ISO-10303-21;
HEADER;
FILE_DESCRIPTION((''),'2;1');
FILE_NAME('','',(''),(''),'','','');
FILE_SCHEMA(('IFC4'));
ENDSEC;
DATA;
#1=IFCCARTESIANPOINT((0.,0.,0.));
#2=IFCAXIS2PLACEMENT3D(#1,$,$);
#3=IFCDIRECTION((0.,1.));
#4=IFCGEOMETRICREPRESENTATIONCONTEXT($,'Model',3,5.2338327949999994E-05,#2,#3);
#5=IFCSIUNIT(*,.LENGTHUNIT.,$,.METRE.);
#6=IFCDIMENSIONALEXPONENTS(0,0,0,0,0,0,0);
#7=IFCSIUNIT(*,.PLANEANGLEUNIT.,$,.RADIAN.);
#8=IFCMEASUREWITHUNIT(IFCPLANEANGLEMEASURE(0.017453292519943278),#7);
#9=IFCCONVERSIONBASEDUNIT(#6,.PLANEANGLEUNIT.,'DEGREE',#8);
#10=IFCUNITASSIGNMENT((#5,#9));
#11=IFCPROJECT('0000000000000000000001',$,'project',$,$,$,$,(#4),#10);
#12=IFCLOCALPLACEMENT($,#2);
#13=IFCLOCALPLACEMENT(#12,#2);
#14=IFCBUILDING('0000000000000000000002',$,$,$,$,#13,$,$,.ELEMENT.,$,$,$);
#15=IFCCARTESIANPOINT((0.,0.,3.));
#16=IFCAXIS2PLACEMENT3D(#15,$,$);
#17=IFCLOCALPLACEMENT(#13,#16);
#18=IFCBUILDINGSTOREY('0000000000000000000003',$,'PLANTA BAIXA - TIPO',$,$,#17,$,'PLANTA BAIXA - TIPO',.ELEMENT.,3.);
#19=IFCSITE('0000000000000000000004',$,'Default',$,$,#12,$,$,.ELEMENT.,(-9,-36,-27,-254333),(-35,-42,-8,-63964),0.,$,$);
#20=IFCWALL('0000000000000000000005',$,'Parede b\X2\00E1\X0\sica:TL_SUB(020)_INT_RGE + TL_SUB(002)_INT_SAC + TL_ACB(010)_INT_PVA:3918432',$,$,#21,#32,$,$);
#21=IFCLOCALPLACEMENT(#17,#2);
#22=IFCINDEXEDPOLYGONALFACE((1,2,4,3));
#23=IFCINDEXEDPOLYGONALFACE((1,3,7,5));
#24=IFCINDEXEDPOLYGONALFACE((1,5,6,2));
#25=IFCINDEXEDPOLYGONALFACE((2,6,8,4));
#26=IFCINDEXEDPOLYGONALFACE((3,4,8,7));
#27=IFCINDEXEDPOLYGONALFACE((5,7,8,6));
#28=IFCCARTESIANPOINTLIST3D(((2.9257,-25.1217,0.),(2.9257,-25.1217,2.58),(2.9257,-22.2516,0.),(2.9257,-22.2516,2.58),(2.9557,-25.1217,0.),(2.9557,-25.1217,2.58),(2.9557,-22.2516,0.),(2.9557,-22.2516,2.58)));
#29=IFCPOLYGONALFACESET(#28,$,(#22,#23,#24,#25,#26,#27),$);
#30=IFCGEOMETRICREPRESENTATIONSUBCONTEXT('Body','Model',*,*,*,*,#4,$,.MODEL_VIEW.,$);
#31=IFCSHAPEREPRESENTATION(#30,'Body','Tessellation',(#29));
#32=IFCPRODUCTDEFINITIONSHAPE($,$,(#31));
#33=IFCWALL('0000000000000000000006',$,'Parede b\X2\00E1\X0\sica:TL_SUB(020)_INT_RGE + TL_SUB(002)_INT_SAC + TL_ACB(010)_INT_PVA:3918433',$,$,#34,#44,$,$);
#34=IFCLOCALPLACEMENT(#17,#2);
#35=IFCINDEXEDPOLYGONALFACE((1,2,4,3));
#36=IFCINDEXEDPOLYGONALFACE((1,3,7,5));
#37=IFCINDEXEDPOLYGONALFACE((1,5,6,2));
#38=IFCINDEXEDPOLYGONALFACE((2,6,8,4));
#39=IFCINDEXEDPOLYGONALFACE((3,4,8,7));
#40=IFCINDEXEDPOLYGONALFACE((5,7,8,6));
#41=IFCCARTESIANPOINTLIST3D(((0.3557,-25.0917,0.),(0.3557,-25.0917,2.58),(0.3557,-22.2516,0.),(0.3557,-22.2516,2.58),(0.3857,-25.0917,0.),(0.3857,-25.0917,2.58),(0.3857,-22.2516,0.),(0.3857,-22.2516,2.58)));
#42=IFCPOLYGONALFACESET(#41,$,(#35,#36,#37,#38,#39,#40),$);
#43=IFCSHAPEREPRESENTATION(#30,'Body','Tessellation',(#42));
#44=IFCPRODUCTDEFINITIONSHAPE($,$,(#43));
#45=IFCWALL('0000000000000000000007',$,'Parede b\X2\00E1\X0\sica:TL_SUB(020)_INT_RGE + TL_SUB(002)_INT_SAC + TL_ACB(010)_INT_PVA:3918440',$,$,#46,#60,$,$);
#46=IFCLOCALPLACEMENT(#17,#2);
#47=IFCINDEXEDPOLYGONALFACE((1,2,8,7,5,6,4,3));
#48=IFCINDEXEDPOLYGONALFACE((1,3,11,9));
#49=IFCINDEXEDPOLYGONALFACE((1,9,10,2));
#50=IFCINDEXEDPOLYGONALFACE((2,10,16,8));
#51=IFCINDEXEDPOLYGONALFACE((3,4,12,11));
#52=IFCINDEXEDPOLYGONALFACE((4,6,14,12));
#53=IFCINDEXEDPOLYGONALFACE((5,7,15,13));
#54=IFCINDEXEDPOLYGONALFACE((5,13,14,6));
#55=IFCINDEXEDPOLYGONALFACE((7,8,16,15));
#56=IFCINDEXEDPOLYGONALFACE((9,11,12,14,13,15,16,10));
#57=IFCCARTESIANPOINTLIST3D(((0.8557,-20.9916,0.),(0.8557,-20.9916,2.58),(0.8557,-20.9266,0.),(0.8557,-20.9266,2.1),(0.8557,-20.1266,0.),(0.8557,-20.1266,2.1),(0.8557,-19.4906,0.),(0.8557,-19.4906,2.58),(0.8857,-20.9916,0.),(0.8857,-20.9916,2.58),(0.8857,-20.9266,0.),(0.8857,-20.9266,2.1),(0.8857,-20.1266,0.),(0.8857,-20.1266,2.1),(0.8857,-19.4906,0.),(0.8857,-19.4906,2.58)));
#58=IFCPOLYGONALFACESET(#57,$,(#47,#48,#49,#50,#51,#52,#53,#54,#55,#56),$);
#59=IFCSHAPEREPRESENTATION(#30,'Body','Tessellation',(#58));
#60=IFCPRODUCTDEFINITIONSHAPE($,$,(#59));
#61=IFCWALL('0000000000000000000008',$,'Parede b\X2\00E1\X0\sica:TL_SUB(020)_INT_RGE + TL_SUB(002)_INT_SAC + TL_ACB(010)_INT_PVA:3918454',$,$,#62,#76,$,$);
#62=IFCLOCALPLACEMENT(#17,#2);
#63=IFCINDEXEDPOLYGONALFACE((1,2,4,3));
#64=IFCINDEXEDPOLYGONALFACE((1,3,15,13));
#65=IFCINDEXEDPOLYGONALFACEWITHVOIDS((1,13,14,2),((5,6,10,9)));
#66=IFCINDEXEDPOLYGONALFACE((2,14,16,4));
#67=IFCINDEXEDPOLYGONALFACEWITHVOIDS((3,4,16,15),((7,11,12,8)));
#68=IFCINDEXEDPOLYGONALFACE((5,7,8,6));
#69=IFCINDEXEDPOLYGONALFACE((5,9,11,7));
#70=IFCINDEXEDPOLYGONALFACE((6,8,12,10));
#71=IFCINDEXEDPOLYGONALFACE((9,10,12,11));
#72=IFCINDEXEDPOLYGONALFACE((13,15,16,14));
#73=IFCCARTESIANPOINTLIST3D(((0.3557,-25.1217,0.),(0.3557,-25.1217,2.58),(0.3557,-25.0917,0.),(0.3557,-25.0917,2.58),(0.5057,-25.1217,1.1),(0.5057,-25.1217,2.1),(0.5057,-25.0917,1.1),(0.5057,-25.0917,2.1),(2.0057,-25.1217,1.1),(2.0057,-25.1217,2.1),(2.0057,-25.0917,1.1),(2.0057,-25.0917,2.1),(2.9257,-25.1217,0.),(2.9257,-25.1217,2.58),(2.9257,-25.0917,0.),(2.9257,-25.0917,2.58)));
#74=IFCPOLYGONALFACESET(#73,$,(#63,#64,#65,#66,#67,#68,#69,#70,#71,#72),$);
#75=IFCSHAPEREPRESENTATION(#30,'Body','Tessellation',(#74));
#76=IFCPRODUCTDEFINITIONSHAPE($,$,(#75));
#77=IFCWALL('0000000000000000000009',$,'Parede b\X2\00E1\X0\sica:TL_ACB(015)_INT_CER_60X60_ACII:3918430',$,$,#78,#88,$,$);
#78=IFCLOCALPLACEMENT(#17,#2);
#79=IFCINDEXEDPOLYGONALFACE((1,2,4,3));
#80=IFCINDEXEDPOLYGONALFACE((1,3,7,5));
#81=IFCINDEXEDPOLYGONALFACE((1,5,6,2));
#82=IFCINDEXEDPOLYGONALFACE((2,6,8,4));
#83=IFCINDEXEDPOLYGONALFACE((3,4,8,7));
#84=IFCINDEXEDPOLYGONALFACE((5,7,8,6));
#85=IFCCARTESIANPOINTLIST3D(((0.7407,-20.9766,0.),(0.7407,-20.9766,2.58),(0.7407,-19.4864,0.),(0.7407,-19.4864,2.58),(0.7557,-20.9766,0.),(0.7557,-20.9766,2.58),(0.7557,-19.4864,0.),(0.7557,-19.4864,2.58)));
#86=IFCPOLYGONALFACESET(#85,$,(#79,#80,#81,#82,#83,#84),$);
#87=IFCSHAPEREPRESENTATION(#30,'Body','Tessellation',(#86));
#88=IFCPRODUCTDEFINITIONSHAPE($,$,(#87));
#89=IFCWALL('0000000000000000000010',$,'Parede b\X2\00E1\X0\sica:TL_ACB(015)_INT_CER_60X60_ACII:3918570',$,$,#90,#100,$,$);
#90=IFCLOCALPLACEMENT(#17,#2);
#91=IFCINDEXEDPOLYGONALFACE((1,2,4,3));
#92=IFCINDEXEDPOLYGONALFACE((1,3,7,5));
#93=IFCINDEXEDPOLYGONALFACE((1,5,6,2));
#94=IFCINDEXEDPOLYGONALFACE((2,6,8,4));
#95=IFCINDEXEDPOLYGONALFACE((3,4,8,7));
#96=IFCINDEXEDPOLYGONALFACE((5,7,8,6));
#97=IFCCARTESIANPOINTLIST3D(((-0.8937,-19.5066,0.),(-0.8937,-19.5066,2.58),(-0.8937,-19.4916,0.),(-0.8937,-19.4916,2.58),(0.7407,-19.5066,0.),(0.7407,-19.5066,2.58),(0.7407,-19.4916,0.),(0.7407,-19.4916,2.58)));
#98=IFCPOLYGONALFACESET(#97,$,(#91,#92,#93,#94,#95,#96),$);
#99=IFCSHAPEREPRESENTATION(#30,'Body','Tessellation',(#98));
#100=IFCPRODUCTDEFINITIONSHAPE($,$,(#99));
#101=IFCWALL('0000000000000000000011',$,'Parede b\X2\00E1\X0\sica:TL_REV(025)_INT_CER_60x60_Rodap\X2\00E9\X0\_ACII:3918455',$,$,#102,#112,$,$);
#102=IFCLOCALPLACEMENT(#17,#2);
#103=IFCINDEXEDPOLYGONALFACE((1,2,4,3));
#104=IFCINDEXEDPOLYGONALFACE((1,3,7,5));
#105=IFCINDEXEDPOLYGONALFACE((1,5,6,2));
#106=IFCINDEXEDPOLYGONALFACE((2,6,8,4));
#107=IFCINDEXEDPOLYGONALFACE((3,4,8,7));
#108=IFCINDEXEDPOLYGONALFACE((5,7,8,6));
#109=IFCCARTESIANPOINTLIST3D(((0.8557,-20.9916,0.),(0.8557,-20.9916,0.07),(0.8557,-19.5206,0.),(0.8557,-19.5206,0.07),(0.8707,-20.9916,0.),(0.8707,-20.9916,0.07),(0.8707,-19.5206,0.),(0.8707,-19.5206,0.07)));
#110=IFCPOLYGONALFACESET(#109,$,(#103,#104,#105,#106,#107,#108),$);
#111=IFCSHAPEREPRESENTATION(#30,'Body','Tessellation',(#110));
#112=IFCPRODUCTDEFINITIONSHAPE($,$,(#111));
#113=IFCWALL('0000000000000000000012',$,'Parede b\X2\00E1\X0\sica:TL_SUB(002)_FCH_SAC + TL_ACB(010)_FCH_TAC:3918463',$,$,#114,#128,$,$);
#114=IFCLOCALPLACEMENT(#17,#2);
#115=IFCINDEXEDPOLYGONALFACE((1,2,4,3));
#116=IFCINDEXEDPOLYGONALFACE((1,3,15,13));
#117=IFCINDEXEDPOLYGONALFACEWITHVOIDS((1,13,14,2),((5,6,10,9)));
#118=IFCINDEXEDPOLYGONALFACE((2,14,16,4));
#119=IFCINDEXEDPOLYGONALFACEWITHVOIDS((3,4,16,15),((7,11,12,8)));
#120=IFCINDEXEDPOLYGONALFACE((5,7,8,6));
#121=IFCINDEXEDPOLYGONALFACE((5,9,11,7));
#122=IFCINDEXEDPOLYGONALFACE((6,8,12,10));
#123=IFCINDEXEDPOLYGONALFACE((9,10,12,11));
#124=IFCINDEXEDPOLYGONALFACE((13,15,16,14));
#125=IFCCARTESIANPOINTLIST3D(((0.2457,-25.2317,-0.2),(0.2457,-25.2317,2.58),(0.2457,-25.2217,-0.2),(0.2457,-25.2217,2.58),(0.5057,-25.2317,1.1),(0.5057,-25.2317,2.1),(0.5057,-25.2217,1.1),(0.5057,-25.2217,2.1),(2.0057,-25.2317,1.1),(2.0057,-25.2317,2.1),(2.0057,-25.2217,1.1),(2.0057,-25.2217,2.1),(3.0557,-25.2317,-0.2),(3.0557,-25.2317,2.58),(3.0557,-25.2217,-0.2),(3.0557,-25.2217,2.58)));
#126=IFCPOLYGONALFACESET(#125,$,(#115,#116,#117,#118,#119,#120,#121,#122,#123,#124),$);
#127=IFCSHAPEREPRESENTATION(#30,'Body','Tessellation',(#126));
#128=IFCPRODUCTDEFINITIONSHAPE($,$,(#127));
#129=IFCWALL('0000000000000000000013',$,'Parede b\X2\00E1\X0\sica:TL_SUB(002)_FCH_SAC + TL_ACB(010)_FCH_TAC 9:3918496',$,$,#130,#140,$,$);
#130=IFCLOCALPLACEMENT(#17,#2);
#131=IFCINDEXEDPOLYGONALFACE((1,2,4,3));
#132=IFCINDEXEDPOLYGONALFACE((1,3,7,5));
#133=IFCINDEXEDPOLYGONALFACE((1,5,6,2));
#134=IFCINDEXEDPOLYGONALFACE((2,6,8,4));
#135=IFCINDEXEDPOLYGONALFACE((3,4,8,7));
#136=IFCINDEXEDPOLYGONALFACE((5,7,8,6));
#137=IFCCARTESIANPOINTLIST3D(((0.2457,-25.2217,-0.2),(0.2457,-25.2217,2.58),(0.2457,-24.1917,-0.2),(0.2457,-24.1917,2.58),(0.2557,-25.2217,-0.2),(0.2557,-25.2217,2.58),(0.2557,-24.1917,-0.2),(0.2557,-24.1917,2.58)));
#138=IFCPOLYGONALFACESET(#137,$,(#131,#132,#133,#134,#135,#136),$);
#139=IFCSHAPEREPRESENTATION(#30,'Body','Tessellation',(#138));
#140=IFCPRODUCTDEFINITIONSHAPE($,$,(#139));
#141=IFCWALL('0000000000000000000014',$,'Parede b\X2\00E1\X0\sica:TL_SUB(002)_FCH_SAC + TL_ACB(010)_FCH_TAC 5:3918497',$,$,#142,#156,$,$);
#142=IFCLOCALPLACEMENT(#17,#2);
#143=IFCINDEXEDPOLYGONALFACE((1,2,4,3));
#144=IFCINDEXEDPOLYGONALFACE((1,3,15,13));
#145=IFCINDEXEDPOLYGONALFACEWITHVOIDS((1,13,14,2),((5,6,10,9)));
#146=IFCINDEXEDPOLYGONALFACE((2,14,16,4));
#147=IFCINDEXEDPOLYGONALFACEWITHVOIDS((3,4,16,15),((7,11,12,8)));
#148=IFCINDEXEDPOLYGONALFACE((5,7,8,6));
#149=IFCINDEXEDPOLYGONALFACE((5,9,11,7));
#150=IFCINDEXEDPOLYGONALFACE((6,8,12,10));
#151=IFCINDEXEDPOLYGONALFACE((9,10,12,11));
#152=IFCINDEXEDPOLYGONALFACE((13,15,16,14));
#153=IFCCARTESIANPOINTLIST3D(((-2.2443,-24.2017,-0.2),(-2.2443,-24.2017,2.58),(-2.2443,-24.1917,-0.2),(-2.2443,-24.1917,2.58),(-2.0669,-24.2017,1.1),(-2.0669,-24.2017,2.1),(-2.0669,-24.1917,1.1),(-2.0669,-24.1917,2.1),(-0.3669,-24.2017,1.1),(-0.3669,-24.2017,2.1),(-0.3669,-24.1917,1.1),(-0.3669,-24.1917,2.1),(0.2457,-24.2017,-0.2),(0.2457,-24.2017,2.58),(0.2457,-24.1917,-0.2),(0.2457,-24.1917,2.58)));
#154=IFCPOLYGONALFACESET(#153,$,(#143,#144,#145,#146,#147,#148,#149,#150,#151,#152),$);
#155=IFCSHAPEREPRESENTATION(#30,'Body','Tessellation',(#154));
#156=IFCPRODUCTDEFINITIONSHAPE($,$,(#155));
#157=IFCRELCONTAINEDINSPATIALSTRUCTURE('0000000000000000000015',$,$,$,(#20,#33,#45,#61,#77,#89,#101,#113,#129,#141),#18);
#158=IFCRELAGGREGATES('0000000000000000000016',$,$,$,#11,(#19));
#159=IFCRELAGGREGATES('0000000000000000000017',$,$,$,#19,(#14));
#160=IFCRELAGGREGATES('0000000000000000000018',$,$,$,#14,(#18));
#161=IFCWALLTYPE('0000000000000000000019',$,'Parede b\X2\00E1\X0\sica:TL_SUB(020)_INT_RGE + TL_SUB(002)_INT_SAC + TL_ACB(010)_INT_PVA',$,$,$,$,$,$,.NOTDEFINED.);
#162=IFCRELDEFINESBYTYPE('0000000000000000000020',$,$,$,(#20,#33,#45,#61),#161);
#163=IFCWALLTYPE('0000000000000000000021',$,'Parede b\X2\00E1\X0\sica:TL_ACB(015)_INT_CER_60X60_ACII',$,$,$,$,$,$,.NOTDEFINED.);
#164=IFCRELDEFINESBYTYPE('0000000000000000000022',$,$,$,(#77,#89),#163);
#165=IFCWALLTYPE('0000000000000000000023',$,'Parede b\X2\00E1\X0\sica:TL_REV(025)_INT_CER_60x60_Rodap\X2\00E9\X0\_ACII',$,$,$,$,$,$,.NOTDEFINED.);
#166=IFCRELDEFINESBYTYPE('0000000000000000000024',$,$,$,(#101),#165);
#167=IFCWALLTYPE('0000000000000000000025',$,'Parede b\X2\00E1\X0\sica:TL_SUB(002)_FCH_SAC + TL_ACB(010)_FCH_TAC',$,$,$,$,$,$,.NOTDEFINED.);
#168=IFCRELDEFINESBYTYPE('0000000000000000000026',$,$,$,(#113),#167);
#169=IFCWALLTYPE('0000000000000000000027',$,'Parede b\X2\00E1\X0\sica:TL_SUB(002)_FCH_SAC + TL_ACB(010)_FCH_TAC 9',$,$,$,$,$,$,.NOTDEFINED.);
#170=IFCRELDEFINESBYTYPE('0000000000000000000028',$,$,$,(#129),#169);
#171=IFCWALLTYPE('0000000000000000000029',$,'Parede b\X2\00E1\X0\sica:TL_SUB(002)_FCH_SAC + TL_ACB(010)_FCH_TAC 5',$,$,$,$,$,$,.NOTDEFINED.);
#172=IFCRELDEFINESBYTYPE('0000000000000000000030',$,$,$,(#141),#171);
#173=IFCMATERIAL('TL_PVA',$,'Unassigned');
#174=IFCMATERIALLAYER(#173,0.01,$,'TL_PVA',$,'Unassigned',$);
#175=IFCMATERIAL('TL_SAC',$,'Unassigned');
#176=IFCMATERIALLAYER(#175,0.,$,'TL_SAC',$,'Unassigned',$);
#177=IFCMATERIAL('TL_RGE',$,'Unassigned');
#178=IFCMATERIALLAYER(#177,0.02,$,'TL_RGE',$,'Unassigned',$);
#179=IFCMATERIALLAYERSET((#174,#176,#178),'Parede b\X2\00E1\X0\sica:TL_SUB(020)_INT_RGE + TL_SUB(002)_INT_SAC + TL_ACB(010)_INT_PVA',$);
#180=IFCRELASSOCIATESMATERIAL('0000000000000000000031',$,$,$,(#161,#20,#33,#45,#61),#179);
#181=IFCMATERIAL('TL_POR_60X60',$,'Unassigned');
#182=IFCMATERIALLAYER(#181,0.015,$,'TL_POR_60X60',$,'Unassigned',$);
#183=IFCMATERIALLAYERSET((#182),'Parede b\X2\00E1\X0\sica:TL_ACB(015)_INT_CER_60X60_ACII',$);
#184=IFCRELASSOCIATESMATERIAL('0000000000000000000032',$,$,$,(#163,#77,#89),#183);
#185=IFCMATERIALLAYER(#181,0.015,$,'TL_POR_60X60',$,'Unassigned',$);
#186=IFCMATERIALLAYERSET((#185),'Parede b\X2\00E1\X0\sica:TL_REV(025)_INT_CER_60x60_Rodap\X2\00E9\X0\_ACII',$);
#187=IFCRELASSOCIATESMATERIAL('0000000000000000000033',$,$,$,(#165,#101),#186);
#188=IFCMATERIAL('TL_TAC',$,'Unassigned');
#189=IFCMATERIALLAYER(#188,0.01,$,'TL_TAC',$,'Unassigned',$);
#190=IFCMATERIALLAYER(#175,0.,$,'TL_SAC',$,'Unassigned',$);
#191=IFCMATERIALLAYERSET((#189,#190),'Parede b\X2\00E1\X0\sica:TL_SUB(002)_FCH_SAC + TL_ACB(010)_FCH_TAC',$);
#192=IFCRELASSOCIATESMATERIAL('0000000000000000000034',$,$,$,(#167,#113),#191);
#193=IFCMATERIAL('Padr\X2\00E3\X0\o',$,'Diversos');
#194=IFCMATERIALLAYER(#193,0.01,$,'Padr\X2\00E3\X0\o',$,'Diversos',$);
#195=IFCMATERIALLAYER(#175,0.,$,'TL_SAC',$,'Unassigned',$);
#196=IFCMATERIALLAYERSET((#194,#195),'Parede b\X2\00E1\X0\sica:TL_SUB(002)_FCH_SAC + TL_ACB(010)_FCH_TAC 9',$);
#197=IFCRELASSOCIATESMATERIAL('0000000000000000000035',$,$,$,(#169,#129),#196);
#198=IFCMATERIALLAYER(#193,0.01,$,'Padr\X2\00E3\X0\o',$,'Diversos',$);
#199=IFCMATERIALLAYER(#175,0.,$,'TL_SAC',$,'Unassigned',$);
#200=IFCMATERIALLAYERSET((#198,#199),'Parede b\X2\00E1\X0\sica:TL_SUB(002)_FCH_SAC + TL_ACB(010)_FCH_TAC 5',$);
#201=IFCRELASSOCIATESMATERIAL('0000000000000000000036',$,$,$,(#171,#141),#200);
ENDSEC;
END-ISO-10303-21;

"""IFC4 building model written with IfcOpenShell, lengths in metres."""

from ifc_helpers import new_model, entity, si_unit, converted_unit, direction, frame, frame_2d, origin, place, context, subcontext, project, spatial, rectangle, extrude, material, layer, layer_set, layer_usage, type_object, element, save


model = new_model("IFC4")

# Units and contexts
model_context = context("Model", 3, precision=5.2338327949999994e-05, world=origin(), true_north=direction((0.0, 1.0)))
body_context = subcontext(model_context, "Body", "Model", "MODEL_VIEW")
ifc_project = project(units=[si_unit("LENGTHUNIT", "METRE"), converted_unit("PLANEANGLEUNIT", "DEGREE", entity("IfcPlaneAngleMeasure", 0.017453292519943278), si_unit("PLANEANGLEUNIT", "RADIAN"), dimensions=[0, 0, 0, 0, 0, 0, 0])], contexts=[model_context])

# Site, building, storey
site_placement = place(None, frame((0.0, 0.0, 0.0)))
site = spatial("IfcSite", under=ifc_project, at=site_placement, Name="Default", CompositionType="ELEMENT", RefLatitude=(-9, -36, -27, -254333), RefLongitude=(-35, -42, -8, -63964), RefElevation=0.0)
building_placement = place(site_placement, origin())
building = spatial("IfcBuilding", under=site, at=building_placement, CompositionType="ELEMENT")
storey_placement = place(building_placement, frame((0.0, 0.0, 3.0)))
storey = spatial("IfcBuildingStorey", under=building, at=storey_placement, Name="PLANTA BAIXA - TIPO", LongName="PLANTA BAIXA - TIPO", CompositionType="ELEMENT", Elevation=3.0)

# Shared definitions
ifc_material_1 = material(Name="TL_PVA", Category="Unassigned")
ifc_layer_1 = layer(ifc_material_1, 0.01, Name="TL_PVA", Category="Unassigned")
ifc_material_2 = material(Name="TL_SAC", Category="Unassigned")
ifc_layer_2 = layer(ifc_material_2, 0.0, Name="TL_SAC", Category="Unassigned")
ifc_material_3 = material(Name="TL_RGE", Category="Unassigned")
ifc_layer_3 = layer(ifc_material_3, 0.02, Name="TL_RGE", Category="Unassigned")
ifc_layer_set_1 = layer_set([ifc_layer_1, ifc_layer_2, ifc_layer_3], Name="Parede básica:TL_SUB(020)_INT_RGE + TL_SUB(002)_INT_SAC + TL_ACB(010)_INT_PVA")
wall_type_1 = type_object("IfcWallType", Name="Parede básica:TL_SUB(020)_INT_RGE + TL_SUB(002)_INT_SAC + TL_ACB(010)_INT_PVA", PredefinedType="NOTDEFINED", material=ifc_layer_set_1)

# Walls
ifc_layer_usage_1 = layer_usage(ifc_layer_set_1, "AXIS2", "POSITIVE", -0.015)
wall_1_placement = place(storey_placement, frame((2.9407, -22.2516, 0.0), z_axis=(0.0, 0.0, 1.0), x_axis=(0.0, -1.0, 0.0)))
element("IfcWall", 1, at=wall_1_placement, inside=storey, type_object=wall_type_1, material=ifc_layer_usage_1, Name="Parede básica:TL_SUB(020)_INT_RGE + TL_SUB(002)_INT_SAC + TL_ACB(010)_INT_PVA:3918432", context=body_context, shape_type="SweptSolid", body=[
    extrude(rectangle(XDim=2.8701, YDim=0.03, at=frame_2d((1.4351, 0.0), x_axis=(-1.0, 0.0))), origin(), (0.0, 0.0, 1.0), 2.58),
])
ifc_layer_usage_2 = layer_usage(ifc_layer_set_1, "AXIS2", "POSITIVE", -0.015)
wall_2_placement = place(storey_placement, frame((0.3707, -25.0917, 0.0), z_axis=(0.0, 0.0, 1.0), x_axis=(0.0, 1.0, 0.0)))
element("IfcWall", 2, at=wall_2_placement, inside=storey, type_object=wall_type_1, material=ifc_layer_usage_2, Name="Parede básica:TL_SUB(020)_INT_RGE + TL_SUB(002)_INT_SAC + TL_ACB(010)_INT_PVA:3918433", context=body_context, shape_type="SweptSolid", body=[
    extrude(rectangle(XDim=2.8401, YDim=0.03, at=frame_2d((1.4201, 0.0), x_axis=(-1.0, 0.0))), origin(), (0.0, 0.0, 1.0), 2.58),
])

# Walls, openings
ifc_layer_usage_3 = layer_usage(ifc_layer_set_1, "AXIS2", "POSITIVE", -0.015)
wall_3_placement = place(storey_placement, frame((0.8707, -20.9916, 0.0), z_axis=(0.0, 0.0, 1.0), x_axis=(0.0, 1.0, 0.0)))
wall_3 = element("IfcWall", 3, at=wall_3_placement, inside=storey, type_object=wall_type_1, material=ifc_layer_usage_3, Name="Parede básica:TL_SUB(020)_INT_RGE + TL_SUB(002)_INT_SAC + TL_ACB(010)_INT_PVA:3918440", context=body_context, shape_type="SweptSolid", body=[
    extrude(rectangle(XDim=1.501, YDim=0.03, at=frame_2d((0.7505, 0.0), x_axis=(-1.0, 0.0))), origin(), (0.0, 0.0, 1.0), 2.58),
])
opening_1_placement = place(wall_3_placement, frame((0.065, -0.015, 0.0)))
element("IfcOpeningElement", 4, at=opening_1_placement, cuts=wall_3, PredefinedType="OPENING", context=body_context, shape_type="SweptSolid", body=[
    extrude(rectangle(XDim=2.1, YDim=0.8, at=frame_2d((1.05, 0.4), x_axis=(1.0, 0.0))), frame((0.0, 0.0, 0.0), z_axis=(0.0, 1.0, 0.0), x_axis=(0.0, 0.0, 1.0)), (0.0, 0.0, 1.0), 0.03),
])
ifc_layer_usage_4 = layer_usage(ifc_layer_set_1, "AXIS2", "POSITIVE", -0.015)
wall_4_placement = place(storey_placement, frame((2.9257, -25.1067, 0.0), z_axis=(0.0, 0.0, 1.0), x_axis=(-1.0, 0.0, 0.0)))
wall_4 = element("IfcWall", 5, at=wall_4_placement, inside=storey, type_object=wall_type_1, material=ifc_layer_usage_4, Name="Parede básica:TL_SUB(020)_INT_RGE + TL_SUB(002)_INT_SAC + TL_ACB(010)_INT_PVA:3918454", context=body_context, shape_type="SweptSolid", body=[
    extrude(rectangle(XDim=2.57, YDim=0.03, at=frame_2d((1.285, 0.0), x_axis=(-1.0, 0.0))), origin(), (0.0, 0.0, 1.0), 2.58),
])
opening_2_placement = place(wall_4_placement, frame((2.9257, -25.1067, 1.1)))
element("IfcOpeningElement", 6, at=opening_2_placement, cuts=wall_4, PredefinedType="OPENING", context=body_context, shape_type="SweptSolid", body=[
    extrude(rectangle(XDim=1.0, YDim=1.5, at=frame_2d((0.0, 0.0), x_axis=(0.0, 1.0))), frame((-1.2557, 23.5977, 0.5), z_axis=(0.0, 1.0, 0.0), x_axis=(1.0, 0.0, 0.0)), (0.0, 0.0, 1.0), 3.048),
])

# Walls
ifc_material_4 = material(Name="TL_POR_60X60", Category="Unassigned")
ifc_layer_4 = layer(ifc_material_4, 0.015, Name="TL_POR_60X60", Category="Unassigned")
ifc_layer_set_2 = layer_set([ifc_layer_4], Name="Parede básica:TL_ACB(015)_INT_CER_60X60_ACII")
ifc_layer_usage_5 = layer_usage(ifc_layer_set_2, "AXIS2", "POSITIVE", -0.0075)
wall_type_2 = type_object("IfcWallType", Name="Parede básica:TL_ACB(015)_INT_CER_60X60_ACII", PredefinedType="NOTDEFINED", material=ifc_layer_set_2)
wall_5_placement = place(storey_placement, frame((0.7482, -19.4864, 0.0), z_axis=(0.0, 0.0, 1.0), x_axis=(0.0, -1.0, 0.0)))
element("IfcWall", 7, at=wall_5_placement, inside=storey, type_object=wall_type_2, material=ifc_layer_usage_5, Name="Parede básica:TL_ACB(015)_INT_CER_60X60_ACII:3918430", context=body_context, shape_type="SweptSolid", body=[
    extrude(rectangle(XDim=1.4902, YDim=0.015, at=frame_2d((0.7451, 0.0), x_axis=(-1.0, 0.0))), origin(), (0.0, 0.0, 1.0), 2.58),
])
ifc_layer_usage_6 = layer_usage(ifc_layer_set_2, "AXIS2", "NEGATIVE", 0.0075)
wall_6_placement = place(storey_placement, frame((0.7407, -19.4991, 0.0), z_axis=(0.0, 0.0, 1.0), x_axis=(-1.0, 0.0, 0.0)))
element("IfcWall", 8, at=wall_6_placement, inside=storey, type_object=wall_type_2, material=ifc_layer_usage_6, Name="Parede básica:TL_ACB(015)_INT_CER_60X60_ACII:3918570", context=body_context, shape_type="SweptSolid", body=[
    extrude(rectangle(XDim=1.6345, YDim=0.015, at=frame_2d((0.8172, 0.0), x_axis=(-1.0, 0.0))), origin(), (0.0, 0.0, 1.0), 2.58),
])
ifc_layer_5 = layer(ifc_material_4, 0.015, Name="TL_POR_60X60", Category="Unassigned")
ifc_layer_set_3 = layer_set([ifc_layer_5], Name="Parede básica:TL_REV(025)_INT_CER_60x60_Rodapé_ACII")
ifc_layer_usage_7 = layer_usage(ifc_layer_set_3, "AXIS2", "NEGATIVE", 0.0075)
wall_type_3 = type_object("IfcWallType", Name="Parede básica:TL_REV(025)_INT_CER_60x60_Rodapé_ACII", PredefinedType="NOTDEFINED", material=ifc_layer_set_3)
wall_7_placement = place(storey_placement, frame((0.8632, -19.5206, 0.0), z_axis=(0.0, 0.0, 1.0), x_axis=(0.0, -1.0, 0.0)))
element("IfcWall", 9, at=wall_7_placement, inside=storey, type_object=wall_type_3, material=ifc_layer_usage_7, Name="Parede básica:TL_REV(025)_INT_CER_60x60_Rodapé_ACII:3918455", context=body_context, shape_type="SweptSolid", body=[
    extrude(rectangle(XDim=1.471, YDim=0.015, at=frame_2d((0.7355, 0.0), x_axis=(-1.0, 0.0))), origin(), (0.0, 0.0, 1.0), 0.07),
])

# Wall, opening
ifc_material_5 = material(Name="TL_TAC", Category="Unassigned")
ifc_layer_6 = layer(ifc_material_5, 0.01, Name="TL_TAC", Category="Unassigned")
ifc_layer_7 = layer(ifc_material_2, 0.0, Name="TL_SAC", Category="Unassigned")
ifc_layer_set_4 = layer_set([ifc_layer_6, ifc_layer_7], Name="Parede básica:TL_SUB(002)_FCH_SAC + TL_ACB(010)_FCH_TAC")
ifc_layer_usage_8 = layer_usage(ifc_layer_set_4, "AXIS2", "NEGATIVE", 0.005)
wall_type_4 = type_object("IfcWallType", Name="Parede básica:TL_SUB(002)_FCH_SAC + TL_ACB(010)_FCH_TAC", PredefinedType="NOTDEFINED", material=ifc_layer_set_4)
wall_8_placement = place(storey_placement, frame((3.0557, -25.2267, -0.2), z_axis=(0.0, 0.0, 1.0), x_axis=(-1.0, 0.0, 0.0)))
wall_8 = element("IfcWall", 10, at=wall_8_placement, inside=storey, type_object=wall_type_4, material=ifc_layer_usage_8, Name="Parede básica:TL_SUB(002)_FCH_SAC + TL_ACB(010)_FCH_TAC:3918463", context=body_context, shape_type="SweptSolid", body=[
    extrude(rectangle(XDim=2.81, YDim=0.01, at=frame_2d((1.405, 0.0), x_axis=(-1.0, 0.0))), origin(), (0.0, 0.0, 1.0), 2.78),
])
opening_3_placement = place(wall_8_placement, frame((3.0557, -25.2267, 1.3)))
element("IfcOpeningElement", 11, at=opening_3_placement, cuts=wall_8, PredefinedType="OPENING", context=body_context, shape_type="SweptSolid", body=[
    extrude(rectangle(XDim=1.0, YDim=1.5, at=frame_2d((0.0, 0.0), x_axis=(0.0, 1.0))), frame((-1.2557, 23.5977, 0.5), z_axis=(0.0, 1.0, 0.0), x_axis=(1.0, 0.0, 0.0)), (0.0, 0.0, 1.0), 3.048),
])

# Wall
ifc_material_6 = material(Name="Padrão", Category="Diversos")
ifc_layer_8 = layer(ifc_material_6, 0.01, Name="Padrão", Category="Diversos")
ifc_layer_9 = layer(ifc_material_2, 0.0, Name="TL_SAC", Category="Unassigned")
ifc_layer_set_5 = layer_set([ifc_layer_8, ifc_layer_9], Name="Parede básica:TL_SUB(002)_FCH_SAC + TL_ACB(010)_FCH_TAC 9")
ifc_layer_usage_9 = layer_usage(ifc_layer_set_5, "AXIS2", "POSITIVE", -0.005)
wall_type_5 = type_object("IfcWallType", Name="Parede básica:TL_SUB(002)_FCH_SAC + TL_ACB(010)_FCH_TAC 9", PredefinedType="NOTDEFINED", material=ifc_layer_set_5)
wall_9_placement = place(storey_placement, frame((0.2507, -25.2217, -0.2), z_axis=(0.0, 0.0, 1.0), x_axis=(0.0, 1.0, 0.0)))
element("IfcWall", 12, at=wall_9_placement, inside=storey, type_object=wall_type_5, material=ifc_layer_usage_9, Name="Parede básica:TL_SUB(002)_FCH_SAC + TL_ACB(010)_FCH_TAC 9:3918496", context=body_context, shape_type="SweptSolid", body=[
    extrude(rectangle(XDim=1.03, YDim=0.01, at=frame_2d((0.515, 0.0), x_axis=(-1.0, 0.0))), origin(), (0.0, 0.0, 1.0), 2.78),
])

# Wall, opening
ifc_layer_10 = layer(ifc_material_6, 0.01, Name="Padrão", Category="Diversos")
ifc_layer_11 = layer(ifc_material_2, 0.0, Name="TL_SAC", Category="Unassigned")
ifc_layer_set_6 = layer_set([ifc_layer_10, ifc_layer_11], Name="Parede básica:TL_SUB(002)_FCH_SAC + TL_ACB(010)_FCH_TAC 5")
ifc_layer_usage_10 = layer_usage(ifc_layer_set_6, "AXIS2", "POSITIVE", -0.005)
wall_type_6 = type_object("IfcWallType", Name="Parede básica:TL_SUB(002)_FCH_SAC + TL_ACB(010)_FCH_TAC 5", PredefinedType="NOTDEFINED", material=ifc_layer_set_6)
wall_10_placement = place(storey_placement, frame((0.2457, -24.1967, -0.2), z_axis=(0.0, 0.0, 1.0), x_axis=(-1.0, 0.0, 0.0)))
wall_10 = element("IfcWall", 13, at=wall_10_placement, inside=storey, type_object=wall_type_6, material=ifc_layer_usage_10, Name="Parede básica:TL_SUB(002)_FCH_SAC + TL_ACB(010)_FCH_TAC 5:3918497", context=body_context, shape_type="SweptSolid", body=[
    extrude(rectangle(XDim=2.49, YDim=0.01, at=frame_2d((1.245, 0.0), x_axis=(-1.0, 0.0))), origin(), (0.0, 0.0, 1.0), 2.78),
])
opening_4_placement = place(wall_10_placement, frame((0.2457, -24.1967, 1.3)))
element("IfcOpeningElement", 14, at=opening_4_placement, cuts=wall_10, PredefinedType="OPENING", context=body_context, shape_type="SweptSolid", body=[
    extrude(rectangle(XDim=1.0, YDim=1.7, at=frame_2d((0.0, 0.0), x_axis=(0.0, 1.0))), frame((1.2169, 22.5677, 0.5), z_axis=(0.0, 1.0, 0.0), x_axis=(1.0, 0.0, 0.0)), (0.0, 0.0, 1.0), 3.048),
])

save(model, "model.ifc")
